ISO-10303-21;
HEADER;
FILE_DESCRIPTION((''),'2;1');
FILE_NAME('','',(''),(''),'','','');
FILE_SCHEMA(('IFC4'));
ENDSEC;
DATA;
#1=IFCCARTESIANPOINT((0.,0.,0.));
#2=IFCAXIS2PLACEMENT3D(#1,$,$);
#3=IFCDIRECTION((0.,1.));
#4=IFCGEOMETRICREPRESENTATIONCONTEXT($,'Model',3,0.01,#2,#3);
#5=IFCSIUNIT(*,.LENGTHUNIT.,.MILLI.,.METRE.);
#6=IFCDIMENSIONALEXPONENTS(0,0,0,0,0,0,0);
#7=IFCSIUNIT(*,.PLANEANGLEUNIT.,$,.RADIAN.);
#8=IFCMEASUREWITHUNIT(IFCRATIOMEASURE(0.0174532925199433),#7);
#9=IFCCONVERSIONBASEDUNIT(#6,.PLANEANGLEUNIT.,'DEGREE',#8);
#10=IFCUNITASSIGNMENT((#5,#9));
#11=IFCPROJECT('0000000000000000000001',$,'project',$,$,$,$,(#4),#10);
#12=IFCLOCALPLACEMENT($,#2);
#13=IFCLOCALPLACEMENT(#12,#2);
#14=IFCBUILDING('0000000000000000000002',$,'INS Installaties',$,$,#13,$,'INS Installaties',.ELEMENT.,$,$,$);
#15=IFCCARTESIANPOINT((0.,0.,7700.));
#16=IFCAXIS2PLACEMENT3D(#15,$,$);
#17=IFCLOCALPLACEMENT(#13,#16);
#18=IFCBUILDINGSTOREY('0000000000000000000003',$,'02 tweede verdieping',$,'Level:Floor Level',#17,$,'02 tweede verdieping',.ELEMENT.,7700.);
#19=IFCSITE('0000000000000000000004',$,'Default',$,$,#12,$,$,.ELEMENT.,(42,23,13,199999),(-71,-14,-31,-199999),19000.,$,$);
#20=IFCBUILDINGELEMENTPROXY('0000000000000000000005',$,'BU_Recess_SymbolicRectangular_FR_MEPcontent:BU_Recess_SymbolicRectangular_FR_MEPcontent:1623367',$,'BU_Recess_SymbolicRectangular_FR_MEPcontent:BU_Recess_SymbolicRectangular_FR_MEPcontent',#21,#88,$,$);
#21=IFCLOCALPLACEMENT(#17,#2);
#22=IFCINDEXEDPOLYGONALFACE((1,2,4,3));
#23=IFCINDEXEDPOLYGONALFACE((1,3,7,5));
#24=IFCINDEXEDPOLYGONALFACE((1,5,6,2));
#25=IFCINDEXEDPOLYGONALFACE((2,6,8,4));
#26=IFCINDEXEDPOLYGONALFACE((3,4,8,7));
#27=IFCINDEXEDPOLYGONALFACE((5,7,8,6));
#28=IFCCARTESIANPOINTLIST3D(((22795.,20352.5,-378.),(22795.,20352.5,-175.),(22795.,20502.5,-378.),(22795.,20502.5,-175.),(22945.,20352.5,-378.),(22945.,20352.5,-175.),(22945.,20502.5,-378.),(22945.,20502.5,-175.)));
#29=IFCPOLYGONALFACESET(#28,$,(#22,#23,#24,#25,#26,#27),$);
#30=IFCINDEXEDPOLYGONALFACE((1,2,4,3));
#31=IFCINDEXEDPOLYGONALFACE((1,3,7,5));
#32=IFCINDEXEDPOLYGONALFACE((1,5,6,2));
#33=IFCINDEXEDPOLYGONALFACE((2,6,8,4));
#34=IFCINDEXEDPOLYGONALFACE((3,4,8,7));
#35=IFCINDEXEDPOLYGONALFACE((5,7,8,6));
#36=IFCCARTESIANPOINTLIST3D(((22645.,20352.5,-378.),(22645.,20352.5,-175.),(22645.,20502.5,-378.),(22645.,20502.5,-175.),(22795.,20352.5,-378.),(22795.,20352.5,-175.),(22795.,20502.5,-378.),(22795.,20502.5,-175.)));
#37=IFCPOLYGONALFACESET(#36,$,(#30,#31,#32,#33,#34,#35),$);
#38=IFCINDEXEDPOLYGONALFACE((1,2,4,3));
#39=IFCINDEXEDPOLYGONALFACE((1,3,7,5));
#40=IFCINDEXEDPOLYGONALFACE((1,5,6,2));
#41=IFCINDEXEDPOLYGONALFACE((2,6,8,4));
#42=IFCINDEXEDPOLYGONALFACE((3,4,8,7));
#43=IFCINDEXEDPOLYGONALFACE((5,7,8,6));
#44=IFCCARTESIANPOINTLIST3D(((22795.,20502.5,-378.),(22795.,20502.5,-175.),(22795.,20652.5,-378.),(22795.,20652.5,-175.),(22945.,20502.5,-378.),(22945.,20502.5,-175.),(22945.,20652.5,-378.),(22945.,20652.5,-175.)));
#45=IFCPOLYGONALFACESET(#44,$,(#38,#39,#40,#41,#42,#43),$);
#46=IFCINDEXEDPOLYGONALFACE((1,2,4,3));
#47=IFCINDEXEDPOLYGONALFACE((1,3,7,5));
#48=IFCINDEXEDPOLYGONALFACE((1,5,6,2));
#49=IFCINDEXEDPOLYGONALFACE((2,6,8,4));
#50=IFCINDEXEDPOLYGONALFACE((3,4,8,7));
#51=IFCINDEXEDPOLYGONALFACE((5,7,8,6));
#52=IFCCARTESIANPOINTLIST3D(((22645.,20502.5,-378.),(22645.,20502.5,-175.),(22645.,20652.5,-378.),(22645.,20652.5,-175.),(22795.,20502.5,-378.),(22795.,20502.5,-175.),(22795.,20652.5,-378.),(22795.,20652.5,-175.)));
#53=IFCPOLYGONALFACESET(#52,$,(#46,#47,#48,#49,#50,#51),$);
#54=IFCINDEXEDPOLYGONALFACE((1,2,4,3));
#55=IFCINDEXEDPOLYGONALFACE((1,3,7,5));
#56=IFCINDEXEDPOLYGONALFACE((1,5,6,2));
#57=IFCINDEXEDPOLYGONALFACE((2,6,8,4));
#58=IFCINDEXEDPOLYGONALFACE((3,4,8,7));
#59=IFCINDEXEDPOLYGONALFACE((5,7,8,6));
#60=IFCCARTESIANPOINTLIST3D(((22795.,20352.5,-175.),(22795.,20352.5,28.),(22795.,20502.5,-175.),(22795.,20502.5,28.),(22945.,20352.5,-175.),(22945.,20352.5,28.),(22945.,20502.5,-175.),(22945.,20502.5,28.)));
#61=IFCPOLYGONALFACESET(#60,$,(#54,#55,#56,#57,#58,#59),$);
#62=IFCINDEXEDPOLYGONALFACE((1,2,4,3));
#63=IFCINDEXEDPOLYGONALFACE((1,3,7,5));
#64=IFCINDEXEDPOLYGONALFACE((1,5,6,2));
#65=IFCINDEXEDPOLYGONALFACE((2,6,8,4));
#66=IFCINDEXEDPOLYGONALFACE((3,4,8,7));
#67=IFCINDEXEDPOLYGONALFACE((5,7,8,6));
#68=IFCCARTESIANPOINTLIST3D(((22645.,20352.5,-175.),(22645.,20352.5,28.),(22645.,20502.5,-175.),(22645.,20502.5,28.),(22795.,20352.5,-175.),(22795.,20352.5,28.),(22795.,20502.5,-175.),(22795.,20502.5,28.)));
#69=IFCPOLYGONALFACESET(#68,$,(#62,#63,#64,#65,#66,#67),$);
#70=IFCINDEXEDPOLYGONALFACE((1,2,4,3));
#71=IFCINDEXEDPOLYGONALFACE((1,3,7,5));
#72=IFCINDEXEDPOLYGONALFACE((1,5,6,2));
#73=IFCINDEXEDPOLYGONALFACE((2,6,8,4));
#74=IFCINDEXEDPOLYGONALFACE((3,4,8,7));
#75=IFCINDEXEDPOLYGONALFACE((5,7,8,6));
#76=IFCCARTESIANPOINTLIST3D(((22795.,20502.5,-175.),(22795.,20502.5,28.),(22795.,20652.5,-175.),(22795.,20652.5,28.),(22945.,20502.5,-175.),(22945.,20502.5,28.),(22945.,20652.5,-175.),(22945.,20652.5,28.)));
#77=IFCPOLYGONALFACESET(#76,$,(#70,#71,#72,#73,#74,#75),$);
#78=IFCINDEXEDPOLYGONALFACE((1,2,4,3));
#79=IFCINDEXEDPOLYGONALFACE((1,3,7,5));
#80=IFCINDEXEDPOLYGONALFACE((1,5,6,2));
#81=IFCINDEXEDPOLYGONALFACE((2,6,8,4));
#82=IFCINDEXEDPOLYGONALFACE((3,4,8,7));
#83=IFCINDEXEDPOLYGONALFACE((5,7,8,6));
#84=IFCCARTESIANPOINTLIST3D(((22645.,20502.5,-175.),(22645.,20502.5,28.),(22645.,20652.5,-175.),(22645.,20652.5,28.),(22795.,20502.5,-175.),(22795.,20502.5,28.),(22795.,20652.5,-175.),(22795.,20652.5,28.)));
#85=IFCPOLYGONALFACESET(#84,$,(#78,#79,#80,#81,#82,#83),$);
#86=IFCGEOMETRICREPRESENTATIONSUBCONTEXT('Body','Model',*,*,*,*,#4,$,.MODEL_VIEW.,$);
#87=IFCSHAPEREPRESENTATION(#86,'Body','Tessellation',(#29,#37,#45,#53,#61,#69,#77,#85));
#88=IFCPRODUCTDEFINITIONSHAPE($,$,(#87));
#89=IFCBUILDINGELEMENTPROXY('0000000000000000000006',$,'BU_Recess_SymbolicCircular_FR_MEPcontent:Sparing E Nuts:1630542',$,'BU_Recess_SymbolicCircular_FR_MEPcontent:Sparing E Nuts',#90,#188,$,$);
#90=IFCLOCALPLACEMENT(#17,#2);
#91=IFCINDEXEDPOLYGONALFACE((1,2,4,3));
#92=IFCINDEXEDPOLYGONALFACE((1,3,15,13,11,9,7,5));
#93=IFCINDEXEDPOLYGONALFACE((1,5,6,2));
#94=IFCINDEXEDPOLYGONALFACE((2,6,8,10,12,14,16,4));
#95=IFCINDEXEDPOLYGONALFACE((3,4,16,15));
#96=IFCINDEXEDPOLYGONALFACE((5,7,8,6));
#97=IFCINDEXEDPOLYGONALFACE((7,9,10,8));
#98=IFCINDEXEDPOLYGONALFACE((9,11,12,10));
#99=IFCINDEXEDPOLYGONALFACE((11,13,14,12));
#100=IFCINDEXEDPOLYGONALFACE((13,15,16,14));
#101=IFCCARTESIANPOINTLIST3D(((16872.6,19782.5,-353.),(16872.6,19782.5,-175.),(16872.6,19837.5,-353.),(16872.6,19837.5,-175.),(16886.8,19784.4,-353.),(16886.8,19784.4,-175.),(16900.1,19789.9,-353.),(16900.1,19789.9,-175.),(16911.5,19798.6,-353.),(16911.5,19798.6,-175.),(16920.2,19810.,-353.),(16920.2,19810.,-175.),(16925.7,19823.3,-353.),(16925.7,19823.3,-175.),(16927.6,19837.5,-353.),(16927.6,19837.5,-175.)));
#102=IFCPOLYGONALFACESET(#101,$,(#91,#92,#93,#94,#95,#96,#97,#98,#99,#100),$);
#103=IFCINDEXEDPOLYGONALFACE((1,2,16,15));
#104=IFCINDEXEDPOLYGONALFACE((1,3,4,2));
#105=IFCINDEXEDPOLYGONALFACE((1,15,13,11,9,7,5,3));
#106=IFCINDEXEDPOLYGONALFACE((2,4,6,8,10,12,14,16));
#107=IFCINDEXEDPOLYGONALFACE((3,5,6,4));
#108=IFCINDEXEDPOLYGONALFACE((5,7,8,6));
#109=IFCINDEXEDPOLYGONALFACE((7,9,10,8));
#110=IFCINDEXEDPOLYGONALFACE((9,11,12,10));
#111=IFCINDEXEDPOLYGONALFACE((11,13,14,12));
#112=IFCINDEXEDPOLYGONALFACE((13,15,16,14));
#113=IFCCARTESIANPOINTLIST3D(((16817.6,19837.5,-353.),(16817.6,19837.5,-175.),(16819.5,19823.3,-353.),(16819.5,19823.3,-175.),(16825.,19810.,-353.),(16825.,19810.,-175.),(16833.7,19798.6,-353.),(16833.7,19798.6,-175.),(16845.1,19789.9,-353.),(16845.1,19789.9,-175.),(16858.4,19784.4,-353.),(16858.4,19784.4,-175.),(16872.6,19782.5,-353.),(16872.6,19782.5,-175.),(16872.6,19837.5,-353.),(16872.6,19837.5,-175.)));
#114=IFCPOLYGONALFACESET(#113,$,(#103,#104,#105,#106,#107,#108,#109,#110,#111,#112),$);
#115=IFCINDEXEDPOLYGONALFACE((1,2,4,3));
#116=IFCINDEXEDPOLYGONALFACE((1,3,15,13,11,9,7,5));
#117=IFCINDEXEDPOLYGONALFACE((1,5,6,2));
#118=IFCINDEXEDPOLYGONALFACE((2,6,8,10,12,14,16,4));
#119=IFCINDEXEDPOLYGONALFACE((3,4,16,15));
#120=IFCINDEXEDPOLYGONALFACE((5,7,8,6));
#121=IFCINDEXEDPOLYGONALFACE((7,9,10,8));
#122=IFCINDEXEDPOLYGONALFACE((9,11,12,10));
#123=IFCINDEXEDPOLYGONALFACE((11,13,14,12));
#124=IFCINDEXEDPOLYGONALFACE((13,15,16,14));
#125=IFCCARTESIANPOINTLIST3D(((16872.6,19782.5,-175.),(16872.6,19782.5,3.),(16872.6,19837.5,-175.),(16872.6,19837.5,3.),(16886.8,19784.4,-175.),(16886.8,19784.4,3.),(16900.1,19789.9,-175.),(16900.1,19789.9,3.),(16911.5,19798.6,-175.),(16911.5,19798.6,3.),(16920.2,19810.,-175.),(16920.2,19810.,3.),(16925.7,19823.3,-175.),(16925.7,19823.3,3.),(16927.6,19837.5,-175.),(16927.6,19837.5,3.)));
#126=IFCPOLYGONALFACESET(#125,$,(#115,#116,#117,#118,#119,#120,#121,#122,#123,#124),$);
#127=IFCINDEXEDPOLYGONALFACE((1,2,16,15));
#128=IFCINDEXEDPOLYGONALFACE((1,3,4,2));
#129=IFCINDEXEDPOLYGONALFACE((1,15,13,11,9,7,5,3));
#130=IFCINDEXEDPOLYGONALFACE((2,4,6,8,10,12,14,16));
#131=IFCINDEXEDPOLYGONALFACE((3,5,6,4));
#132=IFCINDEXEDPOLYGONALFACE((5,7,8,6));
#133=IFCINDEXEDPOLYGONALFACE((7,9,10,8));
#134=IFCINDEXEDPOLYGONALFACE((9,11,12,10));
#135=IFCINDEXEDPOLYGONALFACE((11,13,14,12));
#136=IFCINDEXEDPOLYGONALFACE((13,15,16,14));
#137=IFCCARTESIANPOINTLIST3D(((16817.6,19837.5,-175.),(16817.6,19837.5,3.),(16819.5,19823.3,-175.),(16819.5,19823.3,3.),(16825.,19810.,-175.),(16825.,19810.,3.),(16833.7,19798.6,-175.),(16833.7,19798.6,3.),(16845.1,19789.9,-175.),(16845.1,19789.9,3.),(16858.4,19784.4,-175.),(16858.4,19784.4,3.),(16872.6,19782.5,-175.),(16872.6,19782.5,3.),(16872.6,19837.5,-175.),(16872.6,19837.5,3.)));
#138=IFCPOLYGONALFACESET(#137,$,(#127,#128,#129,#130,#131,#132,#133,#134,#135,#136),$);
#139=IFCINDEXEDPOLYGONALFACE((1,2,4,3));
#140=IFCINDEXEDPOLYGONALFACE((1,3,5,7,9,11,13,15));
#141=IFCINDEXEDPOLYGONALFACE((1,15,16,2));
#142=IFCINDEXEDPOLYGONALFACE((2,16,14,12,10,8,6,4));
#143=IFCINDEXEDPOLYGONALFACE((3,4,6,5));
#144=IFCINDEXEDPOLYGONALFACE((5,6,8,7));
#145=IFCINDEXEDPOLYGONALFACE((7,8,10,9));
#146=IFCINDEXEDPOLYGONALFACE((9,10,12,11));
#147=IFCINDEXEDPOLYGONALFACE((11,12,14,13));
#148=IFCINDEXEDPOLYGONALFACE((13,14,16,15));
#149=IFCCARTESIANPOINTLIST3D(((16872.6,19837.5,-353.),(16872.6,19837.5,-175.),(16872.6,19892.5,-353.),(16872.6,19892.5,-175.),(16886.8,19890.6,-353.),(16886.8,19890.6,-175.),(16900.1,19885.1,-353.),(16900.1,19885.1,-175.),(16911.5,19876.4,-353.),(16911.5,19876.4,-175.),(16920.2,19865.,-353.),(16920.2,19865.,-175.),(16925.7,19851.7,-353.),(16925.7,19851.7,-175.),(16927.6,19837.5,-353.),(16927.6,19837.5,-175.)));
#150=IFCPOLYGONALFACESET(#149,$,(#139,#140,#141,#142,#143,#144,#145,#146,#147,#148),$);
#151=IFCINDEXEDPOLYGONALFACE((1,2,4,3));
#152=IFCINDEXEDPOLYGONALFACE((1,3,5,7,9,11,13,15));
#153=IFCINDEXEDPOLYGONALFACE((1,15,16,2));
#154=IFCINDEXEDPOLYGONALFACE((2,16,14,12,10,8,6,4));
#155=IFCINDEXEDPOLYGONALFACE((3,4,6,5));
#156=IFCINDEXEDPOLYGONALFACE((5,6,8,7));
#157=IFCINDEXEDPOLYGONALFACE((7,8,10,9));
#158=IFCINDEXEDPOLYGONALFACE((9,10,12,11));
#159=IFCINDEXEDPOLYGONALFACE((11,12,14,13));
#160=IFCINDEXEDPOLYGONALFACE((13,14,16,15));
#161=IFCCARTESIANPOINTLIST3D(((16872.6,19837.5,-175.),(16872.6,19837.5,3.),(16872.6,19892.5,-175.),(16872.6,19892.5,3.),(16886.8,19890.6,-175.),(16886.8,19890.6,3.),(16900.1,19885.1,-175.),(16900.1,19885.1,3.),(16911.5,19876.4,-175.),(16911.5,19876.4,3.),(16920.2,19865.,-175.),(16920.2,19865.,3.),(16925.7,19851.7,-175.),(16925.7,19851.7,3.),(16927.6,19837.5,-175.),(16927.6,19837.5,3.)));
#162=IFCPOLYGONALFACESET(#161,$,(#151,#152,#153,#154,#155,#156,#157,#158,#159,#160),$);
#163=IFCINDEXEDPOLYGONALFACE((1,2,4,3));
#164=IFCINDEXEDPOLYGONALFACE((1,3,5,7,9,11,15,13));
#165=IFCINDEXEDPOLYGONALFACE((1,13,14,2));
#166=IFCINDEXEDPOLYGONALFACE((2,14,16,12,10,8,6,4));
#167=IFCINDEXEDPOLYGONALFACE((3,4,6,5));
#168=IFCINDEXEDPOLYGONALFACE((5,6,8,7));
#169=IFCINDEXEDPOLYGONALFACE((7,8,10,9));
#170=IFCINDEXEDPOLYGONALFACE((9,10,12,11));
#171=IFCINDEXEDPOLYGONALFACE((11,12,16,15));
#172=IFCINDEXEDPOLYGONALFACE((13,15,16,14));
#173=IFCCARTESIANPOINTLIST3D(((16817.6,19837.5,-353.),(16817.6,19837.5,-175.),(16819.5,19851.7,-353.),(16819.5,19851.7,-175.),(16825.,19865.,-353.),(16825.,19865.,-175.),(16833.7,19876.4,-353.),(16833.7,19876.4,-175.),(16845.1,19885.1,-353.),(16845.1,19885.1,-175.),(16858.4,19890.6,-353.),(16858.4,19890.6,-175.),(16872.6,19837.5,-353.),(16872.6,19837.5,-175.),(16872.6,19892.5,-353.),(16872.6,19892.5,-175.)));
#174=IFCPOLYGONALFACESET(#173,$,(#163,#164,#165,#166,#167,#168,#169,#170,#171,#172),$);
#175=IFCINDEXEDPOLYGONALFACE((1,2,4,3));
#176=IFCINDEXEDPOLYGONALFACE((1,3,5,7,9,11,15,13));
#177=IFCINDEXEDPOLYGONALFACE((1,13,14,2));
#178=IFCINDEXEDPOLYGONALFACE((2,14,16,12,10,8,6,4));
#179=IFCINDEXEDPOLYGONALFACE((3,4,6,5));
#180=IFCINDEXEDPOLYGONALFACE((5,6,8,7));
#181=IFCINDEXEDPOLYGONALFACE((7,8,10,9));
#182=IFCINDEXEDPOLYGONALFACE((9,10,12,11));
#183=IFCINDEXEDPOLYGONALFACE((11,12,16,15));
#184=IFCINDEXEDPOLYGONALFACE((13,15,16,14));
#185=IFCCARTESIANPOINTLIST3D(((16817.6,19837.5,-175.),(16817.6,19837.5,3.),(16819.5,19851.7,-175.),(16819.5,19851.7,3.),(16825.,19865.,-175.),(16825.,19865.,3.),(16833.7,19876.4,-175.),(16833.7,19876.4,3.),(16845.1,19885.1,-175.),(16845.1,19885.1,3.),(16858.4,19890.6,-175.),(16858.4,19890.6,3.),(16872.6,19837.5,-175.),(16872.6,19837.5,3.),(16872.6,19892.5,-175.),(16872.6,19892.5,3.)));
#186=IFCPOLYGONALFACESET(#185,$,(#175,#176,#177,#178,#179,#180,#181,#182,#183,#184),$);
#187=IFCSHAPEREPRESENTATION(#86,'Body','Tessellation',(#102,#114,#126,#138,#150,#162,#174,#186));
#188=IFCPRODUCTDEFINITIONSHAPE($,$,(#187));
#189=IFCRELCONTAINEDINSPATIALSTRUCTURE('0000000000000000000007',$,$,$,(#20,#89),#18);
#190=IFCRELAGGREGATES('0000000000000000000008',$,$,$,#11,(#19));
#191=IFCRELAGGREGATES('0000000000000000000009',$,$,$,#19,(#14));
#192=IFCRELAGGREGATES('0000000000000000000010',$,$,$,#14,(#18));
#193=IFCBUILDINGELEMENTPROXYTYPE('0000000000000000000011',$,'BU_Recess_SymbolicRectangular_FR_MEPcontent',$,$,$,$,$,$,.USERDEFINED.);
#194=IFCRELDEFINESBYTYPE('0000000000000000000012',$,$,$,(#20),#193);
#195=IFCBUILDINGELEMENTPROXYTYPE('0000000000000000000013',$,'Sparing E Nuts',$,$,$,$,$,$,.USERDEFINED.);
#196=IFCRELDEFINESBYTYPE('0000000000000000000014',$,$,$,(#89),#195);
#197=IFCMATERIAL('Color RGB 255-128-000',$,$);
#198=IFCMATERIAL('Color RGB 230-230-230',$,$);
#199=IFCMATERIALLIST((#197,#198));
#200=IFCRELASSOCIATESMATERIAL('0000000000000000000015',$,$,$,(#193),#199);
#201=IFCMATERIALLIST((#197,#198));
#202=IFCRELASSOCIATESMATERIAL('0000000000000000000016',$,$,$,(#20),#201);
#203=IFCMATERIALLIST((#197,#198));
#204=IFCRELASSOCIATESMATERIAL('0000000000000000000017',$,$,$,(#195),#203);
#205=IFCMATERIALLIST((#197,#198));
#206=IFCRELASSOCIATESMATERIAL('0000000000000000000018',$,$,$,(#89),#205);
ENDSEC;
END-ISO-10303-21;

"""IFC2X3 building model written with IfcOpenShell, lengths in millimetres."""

from ifc_helpers import new_model, entity, si_unit, converted_unit, direction, frame, frame_2d, origin, origin_2d_with_axis, place, context, subcontext, project, spatial, polyline, circle_curve, parameter, trimmed, segment, composite_curve, rectangle, outline, extrude, source, transform, mapped, material, material_list, type_object, type_shapes, element, save


model = new_model("IFC2X3")

# Units and contexts
model_context = context("Model", 3, precision=0.01, world=origin(), true_north=direction((0.0, 1.0)))
body_context = subcontext(model_context, "Body", "Model", "MODEL_VIEW")
ifc_project = project(units=[si_unit("LENGTHUNIT", "METRE", prefix="MILLI"), converted_unit("PLANEANGLEUNIT", "DEGREE", entity("IfcRatioMeasure", 0.0174532925199433), si_unit("PLANEANGLEUNIT", "RADIAN"), dimensions=[0, 0, 0, 0, 0, 0, 0])], contexts=[model_context])

# Site, building, storey
site_placement = place(None, origin())
site = spatial("IfcSite", under=ifc_project, at=site_placement, Name="Default", CompositionType="ELEMENT", RefLatitude=(42, 23, 13, 199999), RefLongitude=(-71, -14, -31, -199999), RefElevation=19000.0)
building_placement = place(site_placement, origin())
building = spatial("IfcBuilding", under=site, at=building_placement, Name="INS Installaties", LongName="INS Installaties", CompositionType="ELEMENT")
storey_placement = place(building_placement, frame((0.0, 0.0, 7700.0)))
storey = spatial("IfcBuildingStorey", under=building, at=storey_placement, Name="02 tweede verdieping", ObjectType="Level:Floor Level", LongName="02 tweede verdieping", CompositionType="ELEMENT", Elevation=7700.0)

# Building element proxies
ifc_material_1 = material(Name="Color RGB 255-128-000")
ifc_material_2 = material(Name="Color RGB 230-230-230")
ifc_material_list_1 = material_list([ifc_material_1, ifc_material_2])
ifc_material_list_2 = material_list([ifc_material_1, ifc_material_2])
building_element_proxy_type_1 = type_object("IfcBuildingElementProxyType", Name="BU_Recess_SymbolicRectangular_FR_MEPcontent", PredefinedType="USERDEFINED", material=ifc_material_list_2)
shared_shape_1 = source(origin(), body_context, "Body", "SweptSolid", [
    extrude(rectangle(XDim=150.0, YDim=150.0, at=origin_2d_with_axis()), frame((75.0, -75.0, -403.0)), (0.0, 0.0, 1.0), 203.0),
    extrude(rectangle(XDim=150.0, YDim=150.0, at=origin_2d_with_axis()), frame((-75.0, -75.0, -403.0), z_axis=(0.0, 0.0, 1.0), x_axis=(0.0, 1.0, 0.0)), (0.0, 0.0, 1.0), 203.0),
    extrude(rectangle(XDim=150.0, YDim=150.0, at=origin_2d_with_axis()), frame((75.0, 75.0, -403.0), z_axis=(0.0, 0.0, 1.0), x_axis=(0.0, -1.0, 0.0)), (0.0, 0.0, 1.0), 203.0),
    extrude(rectangle(XDim=150.0, YDim=150.0, at=frame_2d((0.0, 0.0), x_axis=(1.0, 0.0))), frame((-75.0, 75.0, -403.0), z_axis=(0.0, 0.0, 1.0), x_axis=(-1.0, 0.0, 0.0)), (0.0, 0.0, 1.0), 203.0),
    extrude(rectangle(XDim=150.0, YDim=150.0, at=origin_2d_with_axis()), frame((75.0, -75.0, -200.0)), (0.0, 0.0, 1.0), 203.0),
    extrude(rectangle(XDim=150.0, YDim=150.0, at=origin_2d_with_axis()), frame((-75.0, -75.0, -200.0), z_axis=(0.0, 0.0, 1.0), x_axis=(0.0, 1.0, 0.0)), (0.0, 0.0, 1.0), 203.0),
    extrude(rectangle(XDim=150.0, YDim=150.0, at=frame_2d((0.0, 0.0), x_axis=(1.0, 0.0))), frame((75.0, 75.0, -200.0), z_axis=(0.0, 0.0, 1.0), x_axis=(0.0, -1.0, 0.0)), (0.0, 0.0, 1.0), 203.0),
    extrude(rectangle(XDim=150.0, YDim=150.0, at=frame_2d((0.0, 0.0), x_axis=(1.0, 0.0))), frame((-75.0, 75.0, -200.0), z_axis=(0.0, 0.0, 1.0), x_axis=(-1.0, 0.0, 0.0)), (0.0, 0.0, 1.0), 203.0),
])
type_shapes(building_element_proxy_type_1, [shared_shape_1])
proxy_1_placement = place(storey_placement, frame((22795.0, 20502.5, 25.0)))
element("IfcBuildingElementProxy", 1, at=proxy_1_placement, inside=storey, type_object=building_element_proxy_type_1, material=ifc_material_list_1, Name="BU_Recess_SymbolicRectangular_FR_MEPcontent:BU_Recess_SymbolicRectangular_FR_MEPcontent:1623367", ObjectType="BU_Recess_SymbolicRectangular_FR_MEPcontent:BU_Recess_SymbolicRectangular_FR_MEPcontent", context=body_context, shape_type="MappedRepresentation", body=[
    mapped(shared_shape_1, transform((0.0, 0.0, 0.0), scale=1.0)),
])
ifc_material_list_3 = material_list([ifc_material_1, ifc_material_2])
ifc_material_list_4 = material_list([ifc_material_1, ifc_material_2])
building_element_proxy_type_2 = type_object("IfcBuildingElementProxyType", Name="Sparing E Nuts", PredefinedType="USERDEFINED", material=ifc_material_list_4)
shared_shape_2 = source(origin(), body_context, "Body", "SweptSolid", [
    extrude(outline(composite_curve([segment(polyline([(-36.7, -18.3), (18.3, -18.3)]), True, "CONTINUOUS"), segment(polyline([(18.3, -18.3), (18.3, 36.7)]), True, "CONTINUOUS"), segment(trimmed(circle_curve(frame_2d((18.3, -18.3), x_axis=(1.0, 0.0)), 55.0), [parameter(90.0)], [parameter(180.0)], True, "PARAMETER"), True, "CONTINUOUS")], self_intersect=False)), frame((18.3, -18.3, -353.0), z_axis=(0.0, 0.0, 1.0), x_axis=(-1.0, 0.0, 0.0)), (0.0, 0.0, 1.0), 178.0),
    extrude(outline(composite_curve([segment(trimmed(circle_curve(frame_2d((18.3, 18.3), x_axis=(1.0, 0.0)), 55.0), [parameter(180.0)], [parameter(270.0)], True, "PARAMETER"), True, "CONTINUOUS"), segment(polyline([(18.3, -36.7), (18.3, 18.3)]), True, "CONTINUOUS"), segment(polyline([(18.3, 18.3), (-36.7, 18.3)]), True, "CONTINUOUS")], self_intersect=False)), frame((-18.3, -18.3, -353.0)), (0.0, 0.0, 1.0), 178.0),
    extrude(outline(composite_curve([segment(polyline([(-36.7, -18.3), (18.3, -18.3)]), True, "CONTINUOUS"), segment(polyline([(18.3, -18.3), (18.3, 36.7)]), True, "CONTINUOUS"), segment(trimmed(circle_curve(frame_2d((18.3, -18.3), x_axis=(1.0, 0.0)), 55.0), [parameter(90.0)], [parameter(180.0)], True, "PARAMETER"), True, "CONTINUOUS")], self_intersect=False)), frame((18.3, -18.3, -175.0), z_axis=(0.0, 0.0, 1.0), x_axis=(-1.0, 0.0, 0.0)), (0.0, 0.0, 1.0), 178.0),
    extrude(outline(composite_curve([segment(trimmed(circle_curve(frame_2d((18.3, 18.3), x_axis=(1.0, 0.0)), 55.0), [parameter(180.0)], [parameter(270.0)], True, "PARAMETER"), True, "CONTINUOUS"), segment(polyline([(18.3, -36.7), (18.3, 18.3)]), True, "CONTINUOUS"), segment(polyline([(18.3, 18.3), (-36.7, 18.3)]), True, "CONTINUOUS")], self_intersect=False)), frame((-18.3, -18.3, -175.0)), (0.0, 0.0, 1.0), 178.0),
    extrude(outline(composite_curve([segment(trimmed(circle_curve(frame_2d((18.3, 18.3), x_axis=(1.0, 0.0)), 55.0), [parameter(180.0)], [parameter(270.0)], True, "PARAMETER"), True, "CONTINUOUS"), segment(polyline([(18.3, -36.7), (18.3, 18.3)]), True, "CONTINUOUS"), segment(polyline([(18.3, 18.3), (-36.7, 18.3)]), True, "CONTINUOUS")], self_intersect=False)), frame((18.3, 18.3, -353.0), z_axis=(0.0, 0.0, 1.0), x_axis=(-1.0, 0.0, 0.0)), (0.0, 0.0, 1.0), 178.0),
    extrude(outline(composite_curve([segment(trimmed(circle_curve(frame_2d((18.3, 18.3), x_axis=(1.0, 0.0)), 55.0), [parameter(180.0)], [parameter(270.0)], True, "PARAMETER"), True, "CONTINUOUS"), segment(polyline([(18.3, -36.7), (18.3, 18.3)]), True, "CONTINUOUS"), segment(polyline([(18.3, 18.3), (-36.7, 18.3)]), True, "CONTINUOUS")], self_intersect=False)), frame((18.3, 18.3, -175.0), z_axis=(0.0, 0.0, 1.0), x_axis=(-1.0, 0.0, 0.0)), (0.0, 0.0, 1.0), 178.0),
    extrude(outline(composite_curve([segment(polyline([(-36.7, -18.3), (18.3, -18.3)]), True, "CONTINUOUS"), segment(polyline([(18.3, -18.3), (18.3, 36.7)]), True, "CONTINUOUS"), segment(trimmed(circle_curve(frame_2d((18.3, -18.3), x_axis=(1.0, 0.0)), 55.0), [parameter(90.0)], [parameter(180.0)], True, "PARAMETER"), True, "CONTINUOUS")], self_intersect=False)), frame((-18.3, 18.3, -353.0)), (0.0, 0.0, 1.0), 178.0),
    extrude(outline(composite_curve([segment(polyline([(-36.7, -18.3), (18.3, -18.3)]), True, "CONTINUOUS"), segment(polyline([(18.3, -18.3), (18.3, 36.7)]), True, "CONTINUOUS"), segment(trimmed(circle_curve(frame_2d((18.3, -18.3), x_axis=(1.0, 0.0)), 55.0), [parameter(90.0)], [parameter(180.0)], True, "PARAMETER"), True, "CONTINUOUS")], self_intersect=False)), frame((-18.3, 18.3, -175.0)), (0.0, 0.0, 1.0), 178.0),
])
type_shapes(building_element_proxy_type_2, [shared_shape_2])
proxy_2_placement = place(storey_placement, frame((16872.6, 19837.5, 0.0)))
element("IfcBuildingElementProxy", 2, at=proxy_2_placement, inside=storey, type_object=building_element_proxy_type_2, material=ifc_material_list_3, Name="BU_Recess_SymbolicCircular_FR_MEPcontent:Sparing E Nuts:1630542", ObjectType="BU_Recess_SymbolicCircular_FR_MEPcontent:Sparing E Nuts", context=body_context, shape_type="MappedRepresentation", body=[
    mapped(shared_shape_2, transform((0.0, 0.0, 0.0), scale=1.0)),
])

save(model, "model.ifc")
